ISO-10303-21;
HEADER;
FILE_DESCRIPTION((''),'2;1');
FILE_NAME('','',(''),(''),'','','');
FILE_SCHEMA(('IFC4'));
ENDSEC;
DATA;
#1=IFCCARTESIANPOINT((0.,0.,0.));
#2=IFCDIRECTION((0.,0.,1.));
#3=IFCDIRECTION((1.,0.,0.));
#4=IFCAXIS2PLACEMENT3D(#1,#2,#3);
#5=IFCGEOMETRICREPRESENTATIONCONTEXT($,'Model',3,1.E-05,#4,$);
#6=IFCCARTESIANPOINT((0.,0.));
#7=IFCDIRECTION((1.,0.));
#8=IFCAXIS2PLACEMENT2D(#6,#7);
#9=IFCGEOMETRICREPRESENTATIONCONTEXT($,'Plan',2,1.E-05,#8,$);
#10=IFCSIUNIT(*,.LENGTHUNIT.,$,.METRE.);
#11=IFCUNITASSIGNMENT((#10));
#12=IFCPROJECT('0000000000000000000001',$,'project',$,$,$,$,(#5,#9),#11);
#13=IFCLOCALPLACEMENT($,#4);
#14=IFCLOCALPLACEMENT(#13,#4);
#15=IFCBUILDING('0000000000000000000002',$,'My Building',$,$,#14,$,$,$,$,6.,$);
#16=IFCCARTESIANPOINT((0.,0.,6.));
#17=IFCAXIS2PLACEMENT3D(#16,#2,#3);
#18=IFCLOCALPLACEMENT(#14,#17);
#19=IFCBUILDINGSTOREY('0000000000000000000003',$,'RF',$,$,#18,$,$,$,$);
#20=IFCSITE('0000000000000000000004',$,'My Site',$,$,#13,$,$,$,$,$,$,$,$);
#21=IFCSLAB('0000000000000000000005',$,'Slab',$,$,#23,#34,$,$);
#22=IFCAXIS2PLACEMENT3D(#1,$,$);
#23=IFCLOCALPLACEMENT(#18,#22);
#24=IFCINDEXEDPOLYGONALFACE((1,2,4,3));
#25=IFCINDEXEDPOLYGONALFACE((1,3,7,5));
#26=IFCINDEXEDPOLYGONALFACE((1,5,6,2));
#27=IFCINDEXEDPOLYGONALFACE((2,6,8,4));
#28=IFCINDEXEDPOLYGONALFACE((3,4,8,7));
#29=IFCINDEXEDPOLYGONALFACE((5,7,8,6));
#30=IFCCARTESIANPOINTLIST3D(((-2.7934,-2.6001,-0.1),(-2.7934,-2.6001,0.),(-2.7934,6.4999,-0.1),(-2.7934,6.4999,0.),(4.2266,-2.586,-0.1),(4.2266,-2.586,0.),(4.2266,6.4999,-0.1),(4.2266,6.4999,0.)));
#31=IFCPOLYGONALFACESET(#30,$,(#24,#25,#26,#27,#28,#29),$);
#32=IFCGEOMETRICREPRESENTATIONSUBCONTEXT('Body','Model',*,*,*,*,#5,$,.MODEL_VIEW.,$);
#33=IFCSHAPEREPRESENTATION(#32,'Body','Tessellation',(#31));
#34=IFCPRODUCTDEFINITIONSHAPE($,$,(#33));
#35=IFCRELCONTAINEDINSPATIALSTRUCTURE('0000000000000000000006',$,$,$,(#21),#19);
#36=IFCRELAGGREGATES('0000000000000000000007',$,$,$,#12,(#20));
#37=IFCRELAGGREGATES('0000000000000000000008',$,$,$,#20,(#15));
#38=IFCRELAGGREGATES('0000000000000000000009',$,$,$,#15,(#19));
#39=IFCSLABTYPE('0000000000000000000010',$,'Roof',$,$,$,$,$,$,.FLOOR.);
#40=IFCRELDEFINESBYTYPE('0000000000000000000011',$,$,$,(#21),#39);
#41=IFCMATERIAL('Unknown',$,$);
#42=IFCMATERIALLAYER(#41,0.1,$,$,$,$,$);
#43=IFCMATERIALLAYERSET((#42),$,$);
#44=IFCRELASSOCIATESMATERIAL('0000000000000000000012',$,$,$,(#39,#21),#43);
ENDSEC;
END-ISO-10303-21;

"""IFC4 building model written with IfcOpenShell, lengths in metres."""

from ifc_helpers import new_model, si_unit, frame, origin_with_axes, origin_2d_with_axis, place, context, subcontext, project, spatial, indexed_curve, outline, extrude, material, layer, layer_set, layer_usage, type_object, element, save


model = new_model("IFC4")

# Units and contexts
model_context = context("Model", 3, precision=1e-05, world=origin_with_axes())
plan_context = context("Plan", 2, precision=1e-05, world=origin_2d_with_axis())
body_context = subcontext(model_context, "Body", "Model", "MODEL_VIEW")
ifc_project = project(units=[si_unit("LENGTHUNIT", "METRE")], contexts=[model_context, plan_context])

# Site, building, storey
site_placement = place(None, origin_with_axes())
site = spatial("IfcSite", under=ifc_project, at=site_placement, Name="My Site")
building_placement = place(site_placement, origin_with_axes())
building = spatial("IfcBuilding", under=site, at=building_placement, Name="My Building", ElevationOfTerrain=6.0)
storey_placement = place(building_placement, frame((0.0, 0.0, 6.0), z_axis=(0.0, 0.0, 1.0), x_axis=(1.0, 0.0, 0.0)))
storey = spatial("IfcBuildingStorey", under=building, at=storey_placement, Name="RF")

# Slab
ifc_material = material(Name="Unknown")
ifc_layer = layer(ifc_material, 0.1)
ifc_layer_set = layer_set([ifc_layer])
ifc_layer_usage = layer_usage(ifc_layer_set, "AXIS3", "POSITIVE", -0.1)
slab_type = type_object("IfcSlabType", Name="Roof", PredefinedType="FLOOR", material=ifc_layer_set)
slab_placement = place(storey_placement, frame((4.2266, 6.4999, 0.0), z_axis=(0.0, 0.0, 1.0), x_axis=(1.0, 0.0, 0.0)))
element("IfcSlab", 1, at=slab_placement, inside=storey, type_object=slab_type, material=ifc_layer_usage, Name="Slab", context=body_context, shape_type="SweptSolid", body=[
    extrude(outline(indexed_curve([(0.0, 0.0), (-7.02, 0.0), (-7.02, -9.1), (0.0, -9.0859), (0.0, 0.0)])), frame((0.0, 0.0, -0.1), z_axis=(0.0, 0.0, 1.0), x_axis=(1.0, 0.0, 0.0)), (0.0, 0.0, 1.0), 0.1),
])

save(model, "model.ifc")
